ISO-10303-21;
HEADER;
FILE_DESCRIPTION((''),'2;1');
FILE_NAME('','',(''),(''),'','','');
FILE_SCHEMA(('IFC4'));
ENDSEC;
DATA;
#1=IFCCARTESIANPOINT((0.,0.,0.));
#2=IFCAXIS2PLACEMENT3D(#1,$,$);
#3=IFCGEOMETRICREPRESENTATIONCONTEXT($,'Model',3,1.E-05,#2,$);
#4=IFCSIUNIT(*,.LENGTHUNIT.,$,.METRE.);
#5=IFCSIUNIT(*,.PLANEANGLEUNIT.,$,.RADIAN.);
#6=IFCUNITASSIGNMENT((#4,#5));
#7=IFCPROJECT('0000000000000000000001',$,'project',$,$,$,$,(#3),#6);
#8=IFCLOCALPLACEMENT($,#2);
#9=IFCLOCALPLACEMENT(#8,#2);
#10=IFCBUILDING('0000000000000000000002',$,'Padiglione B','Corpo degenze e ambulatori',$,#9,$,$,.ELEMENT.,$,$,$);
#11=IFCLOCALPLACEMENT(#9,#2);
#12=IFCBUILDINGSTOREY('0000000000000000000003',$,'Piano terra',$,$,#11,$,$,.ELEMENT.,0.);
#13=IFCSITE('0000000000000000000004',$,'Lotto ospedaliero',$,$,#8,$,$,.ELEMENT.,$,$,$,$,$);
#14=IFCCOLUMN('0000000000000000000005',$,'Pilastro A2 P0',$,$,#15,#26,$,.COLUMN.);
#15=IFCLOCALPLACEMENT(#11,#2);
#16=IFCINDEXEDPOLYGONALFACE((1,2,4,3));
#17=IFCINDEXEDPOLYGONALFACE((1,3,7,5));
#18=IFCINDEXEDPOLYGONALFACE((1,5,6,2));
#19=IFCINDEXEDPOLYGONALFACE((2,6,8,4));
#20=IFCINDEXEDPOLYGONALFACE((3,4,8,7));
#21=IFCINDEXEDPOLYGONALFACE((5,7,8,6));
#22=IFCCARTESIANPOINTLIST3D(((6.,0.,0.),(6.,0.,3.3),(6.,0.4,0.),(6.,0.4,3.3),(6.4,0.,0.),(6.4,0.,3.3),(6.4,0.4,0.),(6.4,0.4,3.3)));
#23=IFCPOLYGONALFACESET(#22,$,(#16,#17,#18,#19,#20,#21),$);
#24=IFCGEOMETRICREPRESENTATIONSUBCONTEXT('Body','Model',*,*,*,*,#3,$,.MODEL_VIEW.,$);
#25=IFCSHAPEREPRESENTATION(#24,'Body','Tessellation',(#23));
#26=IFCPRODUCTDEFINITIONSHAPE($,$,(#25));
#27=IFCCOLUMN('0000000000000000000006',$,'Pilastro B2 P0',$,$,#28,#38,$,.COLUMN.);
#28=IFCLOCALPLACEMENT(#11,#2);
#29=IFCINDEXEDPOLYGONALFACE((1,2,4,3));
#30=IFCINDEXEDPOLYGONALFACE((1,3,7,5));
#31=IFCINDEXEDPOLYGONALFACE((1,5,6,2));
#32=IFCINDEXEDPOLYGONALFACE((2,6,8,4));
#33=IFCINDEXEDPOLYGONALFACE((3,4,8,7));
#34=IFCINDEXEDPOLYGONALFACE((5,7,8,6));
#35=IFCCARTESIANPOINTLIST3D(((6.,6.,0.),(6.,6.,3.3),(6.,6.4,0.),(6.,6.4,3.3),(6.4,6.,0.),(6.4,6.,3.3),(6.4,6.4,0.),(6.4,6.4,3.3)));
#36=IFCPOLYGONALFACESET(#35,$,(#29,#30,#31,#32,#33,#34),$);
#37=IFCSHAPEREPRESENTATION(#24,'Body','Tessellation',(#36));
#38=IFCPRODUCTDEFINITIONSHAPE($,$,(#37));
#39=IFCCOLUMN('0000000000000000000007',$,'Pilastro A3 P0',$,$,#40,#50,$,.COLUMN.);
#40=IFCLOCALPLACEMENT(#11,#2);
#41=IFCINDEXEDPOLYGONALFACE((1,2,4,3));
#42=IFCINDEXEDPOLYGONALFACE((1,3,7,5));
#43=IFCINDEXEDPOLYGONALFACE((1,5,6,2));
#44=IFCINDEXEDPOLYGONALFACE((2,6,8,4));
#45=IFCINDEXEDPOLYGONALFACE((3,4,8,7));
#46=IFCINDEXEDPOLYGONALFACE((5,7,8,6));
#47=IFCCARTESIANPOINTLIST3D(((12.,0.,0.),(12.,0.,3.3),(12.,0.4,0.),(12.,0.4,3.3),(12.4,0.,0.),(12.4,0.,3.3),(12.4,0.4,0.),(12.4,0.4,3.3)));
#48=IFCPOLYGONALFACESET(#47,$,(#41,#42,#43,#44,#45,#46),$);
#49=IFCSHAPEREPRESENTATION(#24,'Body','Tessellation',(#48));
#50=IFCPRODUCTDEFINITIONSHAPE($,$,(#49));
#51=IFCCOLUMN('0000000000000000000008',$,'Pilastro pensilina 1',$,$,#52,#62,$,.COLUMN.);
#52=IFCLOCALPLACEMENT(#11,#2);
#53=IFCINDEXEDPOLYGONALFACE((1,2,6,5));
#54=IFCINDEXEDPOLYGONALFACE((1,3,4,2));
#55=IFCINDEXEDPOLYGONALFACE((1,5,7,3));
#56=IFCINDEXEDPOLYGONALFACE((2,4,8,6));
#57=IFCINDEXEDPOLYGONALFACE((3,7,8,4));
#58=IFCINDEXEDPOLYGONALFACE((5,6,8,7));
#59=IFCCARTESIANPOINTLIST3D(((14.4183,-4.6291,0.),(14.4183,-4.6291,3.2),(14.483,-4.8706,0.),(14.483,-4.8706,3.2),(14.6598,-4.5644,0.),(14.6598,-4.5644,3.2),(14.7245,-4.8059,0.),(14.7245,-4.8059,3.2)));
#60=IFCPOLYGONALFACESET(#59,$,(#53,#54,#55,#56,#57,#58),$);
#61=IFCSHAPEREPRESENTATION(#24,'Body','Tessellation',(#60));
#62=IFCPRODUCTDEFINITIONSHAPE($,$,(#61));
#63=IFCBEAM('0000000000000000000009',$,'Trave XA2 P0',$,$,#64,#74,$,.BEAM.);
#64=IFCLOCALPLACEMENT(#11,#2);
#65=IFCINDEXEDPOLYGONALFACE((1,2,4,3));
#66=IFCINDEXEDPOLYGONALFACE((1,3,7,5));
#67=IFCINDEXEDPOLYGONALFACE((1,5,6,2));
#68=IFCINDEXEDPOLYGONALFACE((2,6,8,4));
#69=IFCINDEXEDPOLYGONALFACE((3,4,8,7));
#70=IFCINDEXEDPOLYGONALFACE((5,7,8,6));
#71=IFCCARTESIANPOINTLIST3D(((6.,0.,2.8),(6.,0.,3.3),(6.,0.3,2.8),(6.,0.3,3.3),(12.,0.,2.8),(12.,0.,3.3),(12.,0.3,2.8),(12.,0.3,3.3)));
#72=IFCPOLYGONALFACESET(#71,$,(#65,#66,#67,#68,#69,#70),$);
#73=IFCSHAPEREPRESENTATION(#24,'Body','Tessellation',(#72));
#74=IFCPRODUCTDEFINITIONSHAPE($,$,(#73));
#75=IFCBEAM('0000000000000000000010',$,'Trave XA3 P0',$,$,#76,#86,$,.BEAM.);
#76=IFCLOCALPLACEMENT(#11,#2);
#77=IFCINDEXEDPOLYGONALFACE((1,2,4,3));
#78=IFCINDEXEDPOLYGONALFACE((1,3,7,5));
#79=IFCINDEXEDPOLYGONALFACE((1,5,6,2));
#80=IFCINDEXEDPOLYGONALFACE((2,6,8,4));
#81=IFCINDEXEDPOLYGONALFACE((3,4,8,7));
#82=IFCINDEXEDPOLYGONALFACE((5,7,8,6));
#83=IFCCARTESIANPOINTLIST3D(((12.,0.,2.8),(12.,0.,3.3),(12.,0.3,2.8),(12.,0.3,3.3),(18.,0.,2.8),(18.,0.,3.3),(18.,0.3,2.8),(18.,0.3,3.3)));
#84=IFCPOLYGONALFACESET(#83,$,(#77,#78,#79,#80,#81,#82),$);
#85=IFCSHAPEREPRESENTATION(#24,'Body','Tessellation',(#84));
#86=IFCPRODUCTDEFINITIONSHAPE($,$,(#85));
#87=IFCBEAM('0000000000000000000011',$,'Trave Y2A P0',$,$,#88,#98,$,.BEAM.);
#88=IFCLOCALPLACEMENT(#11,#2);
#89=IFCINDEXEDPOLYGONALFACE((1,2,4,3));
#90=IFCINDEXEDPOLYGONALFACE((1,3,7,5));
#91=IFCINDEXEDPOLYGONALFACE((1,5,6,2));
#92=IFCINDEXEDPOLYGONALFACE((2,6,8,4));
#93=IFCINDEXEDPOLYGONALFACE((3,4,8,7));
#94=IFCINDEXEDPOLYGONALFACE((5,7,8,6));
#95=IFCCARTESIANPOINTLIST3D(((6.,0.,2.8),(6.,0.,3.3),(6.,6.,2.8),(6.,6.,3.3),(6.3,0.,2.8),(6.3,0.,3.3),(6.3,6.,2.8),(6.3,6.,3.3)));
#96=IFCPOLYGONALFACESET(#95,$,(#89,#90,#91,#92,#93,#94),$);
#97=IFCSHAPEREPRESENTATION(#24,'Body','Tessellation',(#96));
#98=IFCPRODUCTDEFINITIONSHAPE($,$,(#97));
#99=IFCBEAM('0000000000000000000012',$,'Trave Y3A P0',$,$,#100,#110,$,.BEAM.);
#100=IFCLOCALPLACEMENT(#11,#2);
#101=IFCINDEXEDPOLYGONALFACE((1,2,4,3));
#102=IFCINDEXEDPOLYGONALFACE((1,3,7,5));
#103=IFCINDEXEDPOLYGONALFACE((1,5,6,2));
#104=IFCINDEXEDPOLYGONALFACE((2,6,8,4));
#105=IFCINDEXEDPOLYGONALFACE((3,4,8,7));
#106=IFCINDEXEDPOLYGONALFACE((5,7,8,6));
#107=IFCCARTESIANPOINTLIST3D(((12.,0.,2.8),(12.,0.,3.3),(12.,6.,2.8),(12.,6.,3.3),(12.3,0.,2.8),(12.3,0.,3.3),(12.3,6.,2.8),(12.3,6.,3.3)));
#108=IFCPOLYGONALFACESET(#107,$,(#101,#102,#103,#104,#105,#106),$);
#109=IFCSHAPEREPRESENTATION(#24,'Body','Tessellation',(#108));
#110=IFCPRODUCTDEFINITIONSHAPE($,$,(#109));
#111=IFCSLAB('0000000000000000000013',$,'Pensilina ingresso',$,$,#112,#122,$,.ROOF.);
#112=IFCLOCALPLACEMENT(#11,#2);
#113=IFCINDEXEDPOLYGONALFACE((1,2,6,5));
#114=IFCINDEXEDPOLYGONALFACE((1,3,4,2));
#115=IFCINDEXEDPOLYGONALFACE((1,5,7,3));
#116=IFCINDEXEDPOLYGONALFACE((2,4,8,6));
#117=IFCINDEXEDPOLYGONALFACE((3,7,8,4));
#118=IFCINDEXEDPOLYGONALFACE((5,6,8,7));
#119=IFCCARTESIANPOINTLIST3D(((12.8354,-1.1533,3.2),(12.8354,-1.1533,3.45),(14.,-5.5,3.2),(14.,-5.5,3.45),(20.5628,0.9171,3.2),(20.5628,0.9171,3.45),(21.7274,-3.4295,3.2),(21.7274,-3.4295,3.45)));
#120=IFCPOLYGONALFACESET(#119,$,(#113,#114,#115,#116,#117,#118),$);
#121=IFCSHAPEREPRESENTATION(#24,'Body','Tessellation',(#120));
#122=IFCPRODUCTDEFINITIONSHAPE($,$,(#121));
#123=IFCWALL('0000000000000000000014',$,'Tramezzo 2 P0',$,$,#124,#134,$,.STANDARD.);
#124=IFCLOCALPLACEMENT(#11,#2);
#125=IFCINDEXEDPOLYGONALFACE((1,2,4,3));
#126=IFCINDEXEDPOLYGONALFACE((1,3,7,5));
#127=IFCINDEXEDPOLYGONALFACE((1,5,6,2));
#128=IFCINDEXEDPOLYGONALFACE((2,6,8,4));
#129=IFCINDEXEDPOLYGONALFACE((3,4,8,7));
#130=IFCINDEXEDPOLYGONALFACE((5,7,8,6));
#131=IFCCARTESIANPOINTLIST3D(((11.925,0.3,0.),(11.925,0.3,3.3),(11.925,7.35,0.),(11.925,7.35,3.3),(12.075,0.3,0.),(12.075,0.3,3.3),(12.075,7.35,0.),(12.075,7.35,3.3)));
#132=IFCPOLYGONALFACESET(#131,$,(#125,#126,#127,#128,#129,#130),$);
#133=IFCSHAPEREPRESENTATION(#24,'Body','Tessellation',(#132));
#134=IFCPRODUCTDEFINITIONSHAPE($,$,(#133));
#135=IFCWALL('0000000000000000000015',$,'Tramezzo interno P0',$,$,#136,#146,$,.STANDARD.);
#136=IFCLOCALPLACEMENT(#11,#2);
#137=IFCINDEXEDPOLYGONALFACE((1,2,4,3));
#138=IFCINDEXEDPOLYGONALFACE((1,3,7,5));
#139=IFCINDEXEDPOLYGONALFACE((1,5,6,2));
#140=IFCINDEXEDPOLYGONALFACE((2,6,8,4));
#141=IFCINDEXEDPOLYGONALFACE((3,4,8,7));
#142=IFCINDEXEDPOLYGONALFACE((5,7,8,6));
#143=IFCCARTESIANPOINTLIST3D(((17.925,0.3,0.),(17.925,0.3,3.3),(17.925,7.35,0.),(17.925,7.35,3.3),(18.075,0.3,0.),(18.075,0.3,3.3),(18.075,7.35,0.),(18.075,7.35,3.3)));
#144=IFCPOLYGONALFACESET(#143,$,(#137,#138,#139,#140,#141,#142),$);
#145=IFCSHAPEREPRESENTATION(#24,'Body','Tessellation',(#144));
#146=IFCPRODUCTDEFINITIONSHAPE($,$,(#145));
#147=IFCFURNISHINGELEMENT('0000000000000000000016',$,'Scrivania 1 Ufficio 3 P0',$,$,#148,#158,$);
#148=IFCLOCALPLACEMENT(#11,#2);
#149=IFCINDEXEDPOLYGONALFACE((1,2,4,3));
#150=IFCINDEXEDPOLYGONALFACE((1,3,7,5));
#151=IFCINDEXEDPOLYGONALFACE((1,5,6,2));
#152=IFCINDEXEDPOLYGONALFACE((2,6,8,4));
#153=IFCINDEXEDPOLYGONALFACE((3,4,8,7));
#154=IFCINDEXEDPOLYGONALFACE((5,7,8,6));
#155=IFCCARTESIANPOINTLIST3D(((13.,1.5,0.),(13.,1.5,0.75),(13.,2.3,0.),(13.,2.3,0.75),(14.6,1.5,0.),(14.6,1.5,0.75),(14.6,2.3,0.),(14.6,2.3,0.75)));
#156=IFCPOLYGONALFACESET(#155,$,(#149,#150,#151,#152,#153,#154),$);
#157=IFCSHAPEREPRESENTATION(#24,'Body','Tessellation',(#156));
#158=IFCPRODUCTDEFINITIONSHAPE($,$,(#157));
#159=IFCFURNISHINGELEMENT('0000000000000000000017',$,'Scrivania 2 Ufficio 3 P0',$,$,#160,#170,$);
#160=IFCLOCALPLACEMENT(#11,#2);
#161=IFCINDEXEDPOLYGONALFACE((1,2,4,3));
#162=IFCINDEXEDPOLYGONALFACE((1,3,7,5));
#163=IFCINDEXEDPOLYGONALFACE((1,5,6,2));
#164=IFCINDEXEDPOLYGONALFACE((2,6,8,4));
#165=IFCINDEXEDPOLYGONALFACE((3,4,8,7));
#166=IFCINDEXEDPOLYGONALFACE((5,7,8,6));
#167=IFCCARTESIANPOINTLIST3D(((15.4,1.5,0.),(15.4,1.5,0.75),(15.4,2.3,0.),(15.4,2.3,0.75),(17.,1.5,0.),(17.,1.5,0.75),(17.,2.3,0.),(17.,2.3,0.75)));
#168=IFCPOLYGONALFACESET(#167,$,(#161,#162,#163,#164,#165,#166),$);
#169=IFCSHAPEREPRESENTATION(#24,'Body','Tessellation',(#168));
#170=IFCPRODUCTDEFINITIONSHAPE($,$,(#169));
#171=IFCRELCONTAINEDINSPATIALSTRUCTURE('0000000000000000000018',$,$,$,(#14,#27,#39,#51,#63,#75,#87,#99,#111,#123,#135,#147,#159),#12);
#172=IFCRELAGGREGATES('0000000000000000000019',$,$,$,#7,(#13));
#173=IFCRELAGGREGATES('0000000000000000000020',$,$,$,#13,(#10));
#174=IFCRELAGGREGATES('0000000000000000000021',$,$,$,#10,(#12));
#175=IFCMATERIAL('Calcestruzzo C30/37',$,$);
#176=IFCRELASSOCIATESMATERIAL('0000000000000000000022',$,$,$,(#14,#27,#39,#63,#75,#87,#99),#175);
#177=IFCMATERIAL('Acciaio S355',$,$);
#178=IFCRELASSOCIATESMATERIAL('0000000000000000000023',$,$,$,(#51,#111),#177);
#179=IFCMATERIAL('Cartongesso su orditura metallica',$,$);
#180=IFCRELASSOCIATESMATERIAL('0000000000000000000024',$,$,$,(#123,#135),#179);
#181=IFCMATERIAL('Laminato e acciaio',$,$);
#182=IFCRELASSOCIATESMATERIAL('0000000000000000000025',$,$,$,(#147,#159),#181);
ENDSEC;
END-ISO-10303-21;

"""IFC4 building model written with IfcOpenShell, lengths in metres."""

from ifc_helpers import new_model, si_unit, frame, frame_2d, origin, place, context, subcontext, project, spatial, rectangle, extrude, material, element, save


model = new_model("IFC4")

# Units and contexts
model_context = context("Model", 3, precision=1e-05, world=origin())
body_context = subcontext(model_context, "Body", "Model", "MODEL_VIEW")
ifc_project = project(units=[si_unit("LENGTHUNIT", "METRE"), si_unit("PLANEANGLEUNIT", "RADIAN")], contexts=[model_context])

# Site, building, storey
site_placement = place(None, origin())
site = spatial("IfcSite", under=ifc_project, at=site_placement, Name="Lotto ospedaliero", CompositionType="ELEMENT")
building_placement = place(site_placement, origin())
building = spatial("IfcBuilding", under=site, at=building_placement, Name="Padiglione B", Description="Corpo degenze e ambulatori", CompositionType="ELEMENT")
storey_placement = place(building_placement, origin())
storey = spatial("IfcBuildingStorey", under=building, at=storey_placement, Name="Piano terra", CompositionType="ELEMENT", Elevation=0.0)

# Columns
ifc_material_1 = material(Name="Calcestruzzo C30/37")
for number, where, name in (
    (1, (6.0, 0.0, 0.0), "Pilastro A2 P0"),
    (2, (6.0, 6.0, 0.0), "Pilastro B2 P0"),
    (3, (12.0, 0.0, 0.0), "Pilastro A3 P0"),
):
    element("IfcColumn", number, at=place(storey_placement, frame(where)), inside=storey, material=ifc_material_1, Name=name, PredefinedType="COLUMN", context=body_context, shape_type="SweptSolid", body=[
        extrude(rectangle(XDim=0.4, YDim=0.4, at=frame_2d((0.2, 0.2))), origin(), (0.0, 0.0, 1.0), 3.3),
    ])
ifc_material_2 = material(Name="Acciaio S355")
column_placement = place(storey_placement, frame((14.483, -4.8706, 0.0), z_axis=(0.0, 0.0, 1.0), x_axis=(0.9659, 0.2588, 0.0)))
element("IfcColumn", 4, at=column_placement, inside=storey, material=ifc_material_2, Name="Pilastro pensilina 1", PredefinedType="COLUMN", context=body_context, shape_type="SweptSolid", body=[
    extrude(rectangle(XDim=0.25, YDim=0.25, at=frame_2d((0.125, 0.125))), origin(), (0.0, 0.0, 1.0), 3.2),
])

# Beams
for number, where, name in (
    (5, (6.0, 0.0, 2.8), "Trave XA2 P0"),
    (6, (12.0, 0.0, 2.8), "Trave XA3 P0"),
):
    element("IfcBeam", number, at=place(storey_placement, frame(where)), inside=storey, material=ifc_material_1, Name=name, PredefinedType="BEAM", context=body_context, shape_type="SweptSolid", body=[
        extrude(rectangle(XDim=6.0, YDim=0.3, at=frame_2d((3.0, 0.15))), origin(), (0.0, 0.0, 1.0), 0.5),
    ])
for number, where, name in (
    (7, (6.0, 0.0, 2.8), "Trave Y2A P0"),
    (8, (12.0, 0.0, 2.8), "Trave Y3A P0"),
):
    element("IfcBeam", number, at=place(storey_placement, frame(where)), inside=storey, material=ifc_material_1, Name=name, PredefinedType="BEAM", context=body_context, shape_type="SweptSolid", body=[
        extrude(rectangle(XDim=0.3, YDim=6.0, at=frame_2d((0.15, 3.0))), origin(), (0.0, 0.0, 1.0), 0.5),
    ])

# Slab
slab_placement = place(storey_placement, frame((14.0, -5.5, 3.2), z_axis=(0.0, 0.0, 1.0), x_axis=(0.9659, 0.2588, 0.0)))
element("IfcSlab", 9, at=slab_placement, inside=storey, material=ifc_material_2, Name="Pensilina ingresso", PredefinedType="ROOF", context=body_context, shape_type="SweptSolid", body=[
    extrude(rectangle(XDim=8.0, YDim=4.5, at=frame_2d((4.0, 2.25))), origin(), (0.0, 0.0, 1.0), 0.25),
])

# Walls
ifc_material_3 = material(Name="Cartongesso su orditura metallica")
for number, where, name in (
    (10, (11.925, 0.3, 0.0), "Tramezzo 2 P0"),
    (11, (17.925, 0.3, 0.0), "Tramezzo interno P0"),
):
    element("IfcWall", number, at=place(storey_placement, frame(where)), inside=storey, material=ifc_material_3, Name=name, PredefinedType="STANDARD", context=body_context, shape_type="SweptSolid", body=[
        extrude(rectangle(XDim=0.15, YDim=7.05, at=frame_2d((0.075, 3.525))), origin(), (0.0, 0.0, 1.0), 3.3),
    ])

# Furnishing elements
ifc_material_4 = material(Name="Laminato e acciaio")
for number, where, name in (
    (12, (13.0, 1.5, 0.0), "Scrivania 1 Ufficio 3 P0"),
    (13, (15.4, 1.5, 0.0), "Scrivania 2 Ufficio 3 P0"),
):
    element("IfcFurnishingElement", number, at=place(storey_placement, frame(where)), inside=storey, material=ifc_material_4, Name=name, context=body_context, shape_type="SweptSolid", body=[
        extrude(rectangle(XDim=1.6, YDim=0.8, at=frame_2d((0.8, 0.4))), origin(), (0.0, 0.0, 1.0), 0.75),
    ])

save(model, "model.ifc")
